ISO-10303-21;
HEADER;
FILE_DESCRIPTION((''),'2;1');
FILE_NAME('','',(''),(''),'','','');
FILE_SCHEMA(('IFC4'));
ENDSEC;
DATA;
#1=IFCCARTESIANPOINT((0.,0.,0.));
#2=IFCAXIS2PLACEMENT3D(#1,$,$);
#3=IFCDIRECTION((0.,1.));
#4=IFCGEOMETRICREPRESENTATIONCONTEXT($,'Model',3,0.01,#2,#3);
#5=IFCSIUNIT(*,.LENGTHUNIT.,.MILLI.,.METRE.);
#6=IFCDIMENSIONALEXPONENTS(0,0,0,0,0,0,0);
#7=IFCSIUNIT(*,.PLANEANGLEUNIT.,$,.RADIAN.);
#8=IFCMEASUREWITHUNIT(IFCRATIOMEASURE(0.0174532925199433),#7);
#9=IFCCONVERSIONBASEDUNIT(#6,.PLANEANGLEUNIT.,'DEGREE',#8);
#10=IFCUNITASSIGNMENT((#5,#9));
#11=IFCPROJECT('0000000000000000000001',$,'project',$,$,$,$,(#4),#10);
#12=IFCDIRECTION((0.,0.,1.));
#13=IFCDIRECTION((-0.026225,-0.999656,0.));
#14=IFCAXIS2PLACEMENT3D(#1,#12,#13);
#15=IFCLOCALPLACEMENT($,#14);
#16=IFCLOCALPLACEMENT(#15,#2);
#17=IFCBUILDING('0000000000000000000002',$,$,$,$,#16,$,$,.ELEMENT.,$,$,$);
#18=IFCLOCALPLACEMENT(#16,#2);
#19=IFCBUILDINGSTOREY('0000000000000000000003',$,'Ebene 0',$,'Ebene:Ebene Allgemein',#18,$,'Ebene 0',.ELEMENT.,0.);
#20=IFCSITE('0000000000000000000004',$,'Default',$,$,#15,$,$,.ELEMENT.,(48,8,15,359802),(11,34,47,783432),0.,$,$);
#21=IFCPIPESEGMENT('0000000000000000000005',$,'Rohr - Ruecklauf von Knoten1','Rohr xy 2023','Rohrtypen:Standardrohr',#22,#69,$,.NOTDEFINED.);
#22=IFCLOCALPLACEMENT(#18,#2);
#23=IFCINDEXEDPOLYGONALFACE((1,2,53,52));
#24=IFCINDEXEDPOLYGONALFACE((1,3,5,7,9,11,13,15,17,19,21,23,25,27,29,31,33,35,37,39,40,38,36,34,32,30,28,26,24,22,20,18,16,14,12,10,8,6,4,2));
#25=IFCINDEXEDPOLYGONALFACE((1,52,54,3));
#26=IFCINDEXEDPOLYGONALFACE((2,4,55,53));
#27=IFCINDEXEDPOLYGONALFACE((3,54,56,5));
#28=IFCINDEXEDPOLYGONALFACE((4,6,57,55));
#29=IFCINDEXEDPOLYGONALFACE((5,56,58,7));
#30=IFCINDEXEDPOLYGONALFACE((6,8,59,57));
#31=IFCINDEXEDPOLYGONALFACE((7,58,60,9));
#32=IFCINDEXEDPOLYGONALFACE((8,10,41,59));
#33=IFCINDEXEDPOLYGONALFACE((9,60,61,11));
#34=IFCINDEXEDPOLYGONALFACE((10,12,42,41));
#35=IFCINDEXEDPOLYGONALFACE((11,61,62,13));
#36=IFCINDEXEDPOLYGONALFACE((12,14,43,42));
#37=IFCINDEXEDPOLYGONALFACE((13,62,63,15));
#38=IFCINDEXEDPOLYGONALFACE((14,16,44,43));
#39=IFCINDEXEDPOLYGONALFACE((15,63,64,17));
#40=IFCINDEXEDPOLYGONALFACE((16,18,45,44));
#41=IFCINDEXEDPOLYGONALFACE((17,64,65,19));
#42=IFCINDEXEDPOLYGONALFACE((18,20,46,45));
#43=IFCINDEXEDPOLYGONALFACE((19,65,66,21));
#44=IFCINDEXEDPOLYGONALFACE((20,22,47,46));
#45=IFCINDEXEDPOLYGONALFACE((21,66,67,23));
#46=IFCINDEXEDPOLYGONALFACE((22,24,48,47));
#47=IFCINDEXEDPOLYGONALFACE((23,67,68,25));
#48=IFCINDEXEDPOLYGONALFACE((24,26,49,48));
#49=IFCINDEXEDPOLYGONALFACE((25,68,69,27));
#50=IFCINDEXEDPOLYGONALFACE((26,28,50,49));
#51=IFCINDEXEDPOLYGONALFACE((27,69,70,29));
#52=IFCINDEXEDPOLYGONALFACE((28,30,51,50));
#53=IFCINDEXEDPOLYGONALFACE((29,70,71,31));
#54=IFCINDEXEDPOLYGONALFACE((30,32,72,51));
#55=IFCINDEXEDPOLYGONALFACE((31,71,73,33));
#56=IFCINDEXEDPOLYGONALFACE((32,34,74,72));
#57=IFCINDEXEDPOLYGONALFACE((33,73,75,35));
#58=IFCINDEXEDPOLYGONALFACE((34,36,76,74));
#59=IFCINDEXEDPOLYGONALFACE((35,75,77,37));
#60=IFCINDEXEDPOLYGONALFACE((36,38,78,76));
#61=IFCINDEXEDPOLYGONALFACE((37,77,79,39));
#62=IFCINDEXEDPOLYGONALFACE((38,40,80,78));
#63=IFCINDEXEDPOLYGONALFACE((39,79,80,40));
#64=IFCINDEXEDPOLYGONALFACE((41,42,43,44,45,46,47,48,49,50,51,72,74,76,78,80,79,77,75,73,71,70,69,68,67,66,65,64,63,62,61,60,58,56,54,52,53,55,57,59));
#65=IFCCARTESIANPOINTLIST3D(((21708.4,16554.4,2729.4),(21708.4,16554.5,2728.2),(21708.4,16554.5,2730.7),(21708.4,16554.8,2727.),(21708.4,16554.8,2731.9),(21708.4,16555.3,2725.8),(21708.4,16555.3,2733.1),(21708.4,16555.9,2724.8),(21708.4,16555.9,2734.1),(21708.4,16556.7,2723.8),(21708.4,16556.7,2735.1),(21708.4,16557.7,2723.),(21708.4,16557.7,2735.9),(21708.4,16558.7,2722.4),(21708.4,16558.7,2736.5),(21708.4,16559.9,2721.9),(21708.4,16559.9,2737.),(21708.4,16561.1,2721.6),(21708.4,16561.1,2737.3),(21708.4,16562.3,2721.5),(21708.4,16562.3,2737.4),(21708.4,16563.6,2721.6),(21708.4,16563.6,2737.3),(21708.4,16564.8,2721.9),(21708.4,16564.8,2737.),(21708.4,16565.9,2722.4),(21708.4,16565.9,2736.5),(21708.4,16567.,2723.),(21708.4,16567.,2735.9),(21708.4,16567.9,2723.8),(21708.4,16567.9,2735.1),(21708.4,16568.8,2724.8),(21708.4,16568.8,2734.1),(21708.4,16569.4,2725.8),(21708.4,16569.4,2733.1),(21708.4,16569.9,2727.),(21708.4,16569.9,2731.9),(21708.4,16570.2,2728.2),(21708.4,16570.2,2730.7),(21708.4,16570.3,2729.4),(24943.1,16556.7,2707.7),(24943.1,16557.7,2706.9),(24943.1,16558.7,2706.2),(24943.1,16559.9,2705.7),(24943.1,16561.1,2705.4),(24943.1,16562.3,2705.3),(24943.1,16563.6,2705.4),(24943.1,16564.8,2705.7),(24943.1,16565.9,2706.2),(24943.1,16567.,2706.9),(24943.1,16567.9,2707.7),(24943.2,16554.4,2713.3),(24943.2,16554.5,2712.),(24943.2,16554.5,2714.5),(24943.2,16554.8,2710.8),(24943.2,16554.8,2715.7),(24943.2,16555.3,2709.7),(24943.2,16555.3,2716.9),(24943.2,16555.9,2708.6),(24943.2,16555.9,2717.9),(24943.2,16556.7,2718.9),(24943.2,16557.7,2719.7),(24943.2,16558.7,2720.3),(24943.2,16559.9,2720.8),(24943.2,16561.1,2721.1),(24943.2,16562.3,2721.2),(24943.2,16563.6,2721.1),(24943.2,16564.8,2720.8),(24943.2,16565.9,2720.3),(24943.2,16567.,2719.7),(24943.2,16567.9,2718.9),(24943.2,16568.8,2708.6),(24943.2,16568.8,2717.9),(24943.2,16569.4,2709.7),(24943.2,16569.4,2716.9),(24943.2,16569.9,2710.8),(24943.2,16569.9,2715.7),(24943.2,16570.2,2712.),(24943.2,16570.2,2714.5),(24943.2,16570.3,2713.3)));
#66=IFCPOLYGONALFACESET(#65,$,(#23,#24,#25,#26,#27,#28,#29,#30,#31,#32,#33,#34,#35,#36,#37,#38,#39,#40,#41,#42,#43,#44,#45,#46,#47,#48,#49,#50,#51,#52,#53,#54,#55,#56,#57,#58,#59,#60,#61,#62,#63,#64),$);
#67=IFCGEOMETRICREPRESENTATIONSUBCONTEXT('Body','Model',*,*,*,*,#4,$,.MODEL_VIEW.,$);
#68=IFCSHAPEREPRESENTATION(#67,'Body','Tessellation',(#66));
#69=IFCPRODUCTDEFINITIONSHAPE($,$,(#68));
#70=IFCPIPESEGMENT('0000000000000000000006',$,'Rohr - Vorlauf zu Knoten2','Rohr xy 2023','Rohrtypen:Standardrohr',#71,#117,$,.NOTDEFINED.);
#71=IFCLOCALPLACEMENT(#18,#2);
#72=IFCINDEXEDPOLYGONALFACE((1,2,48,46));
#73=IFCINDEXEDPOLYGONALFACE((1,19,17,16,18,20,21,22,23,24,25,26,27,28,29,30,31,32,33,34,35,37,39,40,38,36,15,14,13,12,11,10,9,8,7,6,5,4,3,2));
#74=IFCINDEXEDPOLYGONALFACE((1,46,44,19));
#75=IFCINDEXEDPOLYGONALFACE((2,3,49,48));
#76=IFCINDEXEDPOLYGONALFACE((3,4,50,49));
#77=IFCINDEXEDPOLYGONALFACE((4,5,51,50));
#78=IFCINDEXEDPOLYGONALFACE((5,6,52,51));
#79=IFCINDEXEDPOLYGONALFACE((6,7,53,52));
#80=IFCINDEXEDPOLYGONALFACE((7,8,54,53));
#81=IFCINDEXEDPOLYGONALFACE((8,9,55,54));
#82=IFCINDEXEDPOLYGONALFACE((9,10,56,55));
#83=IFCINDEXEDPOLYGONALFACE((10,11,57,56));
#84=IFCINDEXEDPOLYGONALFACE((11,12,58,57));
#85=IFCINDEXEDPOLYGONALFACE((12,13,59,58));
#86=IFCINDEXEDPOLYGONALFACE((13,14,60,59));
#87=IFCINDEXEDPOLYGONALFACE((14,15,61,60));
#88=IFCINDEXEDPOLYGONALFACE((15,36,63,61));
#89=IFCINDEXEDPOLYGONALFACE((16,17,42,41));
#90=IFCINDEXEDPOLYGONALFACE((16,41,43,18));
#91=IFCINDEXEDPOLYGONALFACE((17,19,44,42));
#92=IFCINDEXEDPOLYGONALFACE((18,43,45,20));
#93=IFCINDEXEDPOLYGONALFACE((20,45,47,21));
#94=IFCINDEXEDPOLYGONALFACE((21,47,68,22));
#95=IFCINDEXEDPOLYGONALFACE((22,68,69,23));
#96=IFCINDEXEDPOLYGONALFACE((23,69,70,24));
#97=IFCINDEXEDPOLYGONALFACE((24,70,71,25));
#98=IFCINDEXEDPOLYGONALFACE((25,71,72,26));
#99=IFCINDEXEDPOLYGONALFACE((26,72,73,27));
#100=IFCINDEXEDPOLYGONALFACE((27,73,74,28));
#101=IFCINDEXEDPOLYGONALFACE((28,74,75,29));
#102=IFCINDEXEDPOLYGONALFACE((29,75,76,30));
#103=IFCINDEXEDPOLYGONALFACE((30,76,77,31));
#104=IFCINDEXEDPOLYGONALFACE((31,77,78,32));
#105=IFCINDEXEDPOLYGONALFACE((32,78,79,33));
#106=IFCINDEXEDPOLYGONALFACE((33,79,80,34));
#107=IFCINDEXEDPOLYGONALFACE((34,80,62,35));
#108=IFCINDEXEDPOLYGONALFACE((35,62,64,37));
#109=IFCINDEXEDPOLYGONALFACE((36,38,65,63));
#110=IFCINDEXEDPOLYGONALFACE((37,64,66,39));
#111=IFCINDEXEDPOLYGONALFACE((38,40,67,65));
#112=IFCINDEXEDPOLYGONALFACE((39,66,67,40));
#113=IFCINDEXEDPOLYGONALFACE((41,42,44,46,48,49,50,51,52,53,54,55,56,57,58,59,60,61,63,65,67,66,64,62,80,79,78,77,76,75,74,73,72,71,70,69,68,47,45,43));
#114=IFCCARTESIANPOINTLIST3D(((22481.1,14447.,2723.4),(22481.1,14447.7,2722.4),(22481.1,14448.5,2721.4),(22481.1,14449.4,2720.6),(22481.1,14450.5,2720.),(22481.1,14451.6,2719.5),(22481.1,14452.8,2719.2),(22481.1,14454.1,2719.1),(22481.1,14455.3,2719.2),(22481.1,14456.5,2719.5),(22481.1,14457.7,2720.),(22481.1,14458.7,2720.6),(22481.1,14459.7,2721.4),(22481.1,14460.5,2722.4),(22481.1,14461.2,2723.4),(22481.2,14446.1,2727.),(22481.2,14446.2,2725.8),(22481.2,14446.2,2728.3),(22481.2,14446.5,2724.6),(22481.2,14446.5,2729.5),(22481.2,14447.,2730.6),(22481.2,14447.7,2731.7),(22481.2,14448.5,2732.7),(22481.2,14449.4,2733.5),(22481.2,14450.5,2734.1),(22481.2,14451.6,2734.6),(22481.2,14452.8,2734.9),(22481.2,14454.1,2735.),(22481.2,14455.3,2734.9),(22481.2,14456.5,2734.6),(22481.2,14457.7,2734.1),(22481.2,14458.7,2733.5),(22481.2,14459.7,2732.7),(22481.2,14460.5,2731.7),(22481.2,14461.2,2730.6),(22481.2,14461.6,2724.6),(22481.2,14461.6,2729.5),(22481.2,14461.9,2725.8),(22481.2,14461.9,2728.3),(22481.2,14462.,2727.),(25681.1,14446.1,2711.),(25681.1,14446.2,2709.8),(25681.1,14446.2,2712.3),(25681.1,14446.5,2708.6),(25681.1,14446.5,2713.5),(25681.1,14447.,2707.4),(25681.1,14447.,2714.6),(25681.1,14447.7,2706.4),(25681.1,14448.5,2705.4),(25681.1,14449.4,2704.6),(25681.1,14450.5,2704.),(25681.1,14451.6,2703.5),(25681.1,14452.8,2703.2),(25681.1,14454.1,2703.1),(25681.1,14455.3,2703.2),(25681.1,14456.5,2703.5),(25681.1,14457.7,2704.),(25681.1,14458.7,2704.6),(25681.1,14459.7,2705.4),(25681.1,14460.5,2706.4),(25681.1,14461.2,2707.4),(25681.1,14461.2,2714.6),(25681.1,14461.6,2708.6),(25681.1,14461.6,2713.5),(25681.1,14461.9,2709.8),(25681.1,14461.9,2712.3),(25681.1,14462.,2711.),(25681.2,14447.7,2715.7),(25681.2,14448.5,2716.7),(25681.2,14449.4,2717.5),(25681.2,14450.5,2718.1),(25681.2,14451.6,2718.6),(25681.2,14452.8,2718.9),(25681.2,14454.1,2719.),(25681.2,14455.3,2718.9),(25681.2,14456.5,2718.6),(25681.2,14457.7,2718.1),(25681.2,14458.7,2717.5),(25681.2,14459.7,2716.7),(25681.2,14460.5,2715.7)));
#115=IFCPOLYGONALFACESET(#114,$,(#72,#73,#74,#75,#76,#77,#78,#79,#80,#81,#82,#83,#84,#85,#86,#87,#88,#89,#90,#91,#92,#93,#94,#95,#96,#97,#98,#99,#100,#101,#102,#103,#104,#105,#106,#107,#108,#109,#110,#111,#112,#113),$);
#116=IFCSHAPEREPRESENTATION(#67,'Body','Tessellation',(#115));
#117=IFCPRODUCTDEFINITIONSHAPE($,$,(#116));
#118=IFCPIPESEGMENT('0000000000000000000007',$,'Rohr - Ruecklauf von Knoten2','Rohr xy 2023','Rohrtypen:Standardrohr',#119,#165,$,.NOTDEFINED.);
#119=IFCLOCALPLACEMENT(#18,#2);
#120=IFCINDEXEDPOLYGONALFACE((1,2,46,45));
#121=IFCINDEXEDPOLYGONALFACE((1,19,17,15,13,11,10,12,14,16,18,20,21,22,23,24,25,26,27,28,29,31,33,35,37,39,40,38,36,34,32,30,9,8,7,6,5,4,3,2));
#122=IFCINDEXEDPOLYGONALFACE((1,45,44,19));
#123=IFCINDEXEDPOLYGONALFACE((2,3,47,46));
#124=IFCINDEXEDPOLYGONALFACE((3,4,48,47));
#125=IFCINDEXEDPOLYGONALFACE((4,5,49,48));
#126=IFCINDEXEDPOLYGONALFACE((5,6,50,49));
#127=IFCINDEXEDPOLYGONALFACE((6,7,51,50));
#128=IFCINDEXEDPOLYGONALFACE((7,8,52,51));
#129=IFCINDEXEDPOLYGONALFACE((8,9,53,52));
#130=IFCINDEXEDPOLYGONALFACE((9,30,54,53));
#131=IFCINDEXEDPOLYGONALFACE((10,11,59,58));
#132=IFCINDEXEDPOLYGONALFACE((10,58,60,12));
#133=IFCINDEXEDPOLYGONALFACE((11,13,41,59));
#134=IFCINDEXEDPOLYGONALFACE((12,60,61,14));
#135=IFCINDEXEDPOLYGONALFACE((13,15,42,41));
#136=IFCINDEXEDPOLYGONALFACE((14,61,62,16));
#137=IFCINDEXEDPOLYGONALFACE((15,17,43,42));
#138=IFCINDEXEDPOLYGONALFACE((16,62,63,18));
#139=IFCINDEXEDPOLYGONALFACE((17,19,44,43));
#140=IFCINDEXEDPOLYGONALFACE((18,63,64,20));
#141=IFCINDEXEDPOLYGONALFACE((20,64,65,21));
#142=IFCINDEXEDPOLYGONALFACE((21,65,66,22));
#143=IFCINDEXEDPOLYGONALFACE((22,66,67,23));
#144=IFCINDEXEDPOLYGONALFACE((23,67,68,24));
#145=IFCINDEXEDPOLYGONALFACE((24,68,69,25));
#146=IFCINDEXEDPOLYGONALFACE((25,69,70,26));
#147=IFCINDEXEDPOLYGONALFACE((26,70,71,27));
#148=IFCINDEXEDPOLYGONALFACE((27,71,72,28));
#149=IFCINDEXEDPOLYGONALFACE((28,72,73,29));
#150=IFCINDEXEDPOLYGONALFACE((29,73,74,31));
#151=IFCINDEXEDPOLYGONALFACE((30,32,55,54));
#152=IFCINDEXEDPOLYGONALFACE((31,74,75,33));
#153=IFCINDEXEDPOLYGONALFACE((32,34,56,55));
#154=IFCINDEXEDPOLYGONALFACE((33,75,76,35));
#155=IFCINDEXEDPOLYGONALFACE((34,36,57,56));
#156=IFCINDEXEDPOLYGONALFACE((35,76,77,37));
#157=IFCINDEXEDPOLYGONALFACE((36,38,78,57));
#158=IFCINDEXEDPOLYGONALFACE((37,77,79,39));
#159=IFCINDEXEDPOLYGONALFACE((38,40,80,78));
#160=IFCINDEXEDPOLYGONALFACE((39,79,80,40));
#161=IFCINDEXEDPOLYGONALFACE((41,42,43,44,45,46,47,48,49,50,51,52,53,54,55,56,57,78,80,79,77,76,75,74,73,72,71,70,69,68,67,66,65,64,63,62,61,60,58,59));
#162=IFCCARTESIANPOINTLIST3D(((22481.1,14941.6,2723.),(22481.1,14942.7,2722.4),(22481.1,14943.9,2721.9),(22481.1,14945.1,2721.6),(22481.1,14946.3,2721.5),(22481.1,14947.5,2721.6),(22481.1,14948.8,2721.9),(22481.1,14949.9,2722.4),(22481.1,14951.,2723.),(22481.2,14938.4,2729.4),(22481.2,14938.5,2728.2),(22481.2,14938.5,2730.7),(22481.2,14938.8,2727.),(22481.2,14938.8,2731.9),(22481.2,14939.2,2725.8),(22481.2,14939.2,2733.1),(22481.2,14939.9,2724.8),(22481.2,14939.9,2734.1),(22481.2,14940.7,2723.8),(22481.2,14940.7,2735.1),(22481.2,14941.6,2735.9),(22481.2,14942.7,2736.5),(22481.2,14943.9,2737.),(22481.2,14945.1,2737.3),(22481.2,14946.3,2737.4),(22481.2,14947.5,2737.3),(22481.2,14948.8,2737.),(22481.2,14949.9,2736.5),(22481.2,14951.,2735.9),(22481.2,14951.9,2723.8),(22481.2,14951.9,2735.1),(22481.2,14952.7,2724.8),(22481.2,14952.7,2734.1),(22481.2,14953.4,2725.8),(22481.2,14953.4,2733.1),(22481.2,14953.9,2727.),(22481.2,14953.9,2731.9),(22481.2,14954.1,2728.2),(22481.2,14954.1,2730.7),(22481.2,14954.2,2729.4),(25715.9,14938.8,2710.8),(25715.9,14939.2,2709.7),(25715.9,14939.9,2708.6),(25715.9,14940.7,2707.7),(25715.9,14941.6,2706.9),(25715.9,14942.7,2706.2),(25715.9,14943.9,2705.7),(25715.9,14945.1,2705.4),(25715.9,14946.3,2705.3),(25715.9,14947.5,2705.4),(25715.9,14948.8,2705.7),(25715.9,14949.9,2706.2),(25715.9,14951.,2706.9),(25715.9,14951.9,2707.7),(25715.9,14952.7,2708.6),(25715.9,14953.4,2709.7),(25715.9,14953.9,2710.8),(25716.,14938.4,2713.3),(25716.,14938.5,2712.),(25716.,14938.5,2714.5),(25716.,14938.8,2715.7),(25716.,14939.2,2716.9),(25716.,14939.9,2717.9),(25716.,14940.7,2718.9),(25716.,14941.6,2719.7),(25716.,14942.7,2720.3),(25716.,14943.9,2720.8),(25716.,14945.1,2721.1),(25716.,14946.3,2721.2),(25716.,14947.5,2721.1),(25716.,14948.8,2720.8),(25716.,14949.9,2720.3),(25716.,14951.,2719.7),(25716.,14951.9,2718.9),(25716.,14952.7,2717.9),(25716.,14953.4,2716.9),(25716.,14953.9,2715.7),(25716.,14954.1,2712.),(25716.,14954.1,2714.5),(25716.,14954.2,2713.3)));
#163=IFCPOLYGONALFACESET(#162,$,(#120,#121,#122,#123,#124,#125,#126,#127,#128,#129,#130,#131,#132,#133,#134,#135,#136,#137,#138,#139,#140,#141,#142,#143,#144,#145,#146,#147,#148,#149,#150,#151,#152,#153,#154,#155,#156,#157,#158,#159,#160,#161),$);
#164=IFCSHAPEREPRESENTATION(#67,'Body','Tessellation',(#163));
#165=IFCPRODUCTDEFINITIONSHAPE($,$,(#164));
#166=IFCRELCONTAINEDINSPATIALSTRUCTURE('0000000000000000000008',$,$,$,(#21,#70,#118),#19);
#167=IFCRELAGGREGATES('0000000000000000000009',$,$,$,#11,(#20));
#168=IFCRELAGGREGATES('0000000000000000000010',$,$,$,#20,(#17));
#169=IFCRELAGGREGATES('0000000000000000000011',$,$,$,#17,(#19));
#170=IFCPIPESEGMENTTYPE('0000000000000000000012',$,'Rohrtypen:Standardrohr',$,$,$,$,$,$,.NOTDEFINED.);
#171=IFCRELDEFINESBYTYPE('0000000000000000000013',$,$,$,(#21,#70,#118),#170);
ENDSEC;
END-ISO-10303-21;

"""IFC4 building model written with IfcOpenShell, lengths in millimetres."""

from ifc_helpers import new_model, entity, si_unit, converted_unit, direction, frame, origin, place, context, subcontext, project, spatial, indexed_curve, outline, extrude, type_object, element, save


model = new_model("IFC4")

# Units and contexts
model_context = context("Model", 3, precision=0.01, world=origin(), true_north=direction((0.0, 1.0)))
body_context = subcontext(model_context, "Body", "Model", "MODEL_VIEW")
ifc_project = project(units=[si_unit("LENGTHUNIT", "METRE", prefix="MILLI"), converted_unit("PLANEANGLEUNIT", "DEGREE", entity("IfcRatioMeasure", 0.0174532925199433), si_unit("PLANEANGLEUNIT", "RADIAN"), dimensions=[0, 0, 0, 0, 0, 0, 0])], contexts=[model_context])

# Site, building, storey
site_placement = place(None, frame((0.0, 0.0, 0.0), z_axis=(0.0, 0.0, 1.0), x_axis=(-0.026225, -0.999656, 0.0)))
site = spatial("IfcSite", under=ifc_project, at=site_placement, Name="Default", CompositionType="ELEMENT", RefLatitude=(48, 8, 15, 359802), RefLongitude=(11, 34, 47, 783432), RefElevation=0.0)
building_placement = place(site_placement, origin())
building = spatial("IfcBuilding", under=site, at=building_placement, CompositionType="ELEMENT")
storey_placement = place(building_placement, origin())
storey = spatial("IfcBuildingStorey", under=building, at=storey_placement, Name="Ebene 0", ObjectType="Ebene:Ebene Allgemein", LongName="Ebene 0", CompositionType="ELEMENT", Elevation=0.0)

# Pipe segments
pipe_segment_type = type_object("IfcPipeSegmentType", Name="Rohrtypen:Standardrohr", PredefinedType="NOTDEFINED")
pipe_segment_1_placement = place(storey_placement, origin())
element("IfcPipeSegment", 1, at=pipe_segment_1_placement, inside=storey, type_object=pipe_segment_type, Name="Rohr - Ruecklauf von Knoten1", Description="Rohr xy 2023", ObjectType="Rohrtypen:Standardrohr", PredefinedType="NOTDEFINED", context=body_context, shape_type="SweptSolid", body=[
    extrude(outline(indexed_curve([(7.9, 0.0), (7.8, 1.2), (7.6, 2.5), (7.1, 3.6), (6.4, 4.7), (5.6, 5.6), (4.7, 6.4), (3.6, 7.1), (2.5, 7.6), (1.2, 7.8), (0.0, 7.9), (-1.2, 7.8), (-2.5, 7.6), (-3.6, 7.1), (-4.7, 6.4), (-5.6, 5.6), (-6.4, 4.7), (-7.1, 3.6), (-7.6, 2.5), (-7.8, 1.2), (-7.9, 0.0), (-7.8, -1.2), (-7.6, -2.5), (-7.1, -3.6), (-6.4, -4.7), (-5.6, -5.6), (-4.7, -6.4), (-3.6, -7.1), (-2.5, -7.6), (-1.2, -7.8), (0.0, -7.9), (1.2, -7.8), (2.5, -7.6), (3.6, -7.1), (4.7, -6.4), (5.6, -5.6), (6.4, -4.7), (7.1, -3.6), (7.6, -2.5), (7.8, -1.2), (7.9, 0.0)], self_intersect=False)), frame((24943.2, 16562.3, 2713.3), z_axis=(-0.999988, 0.0, 0.005), x_axis=(0.0, 1.0, 0.0)), (0.0, 0.0, 1.0), 3234.8),
])
pipe_segment_2_placement = place(storey_placement, origin())
element("IfcPipeSegment", 2, at=pipe_segment_2_placement, inside=storey, type_object=pipe_segment_type, Name="Rohr - Vorlauf zu Knoten2", Description="Rohr xy 2023", ObjectType="Rohrtypen:Standardrohr", PredefinedType="NOTDEFINED", context=body_context, shape_type="SweptSolid", body=[
    extrude(outline(indexed_curve([(7.9, 0.0), (7.8, 1.2), (7.6, 2.5), (7.1, 3.6), (6.4, 4.7), (5.6, 5.6), (4.7, 6.4), (3.6, 7.1), (2.5, 7.6), (1.2, 7.8), (0.0, 7.9), (-1.2, 7.8), (-2.5, 7.6), (-3.6, 7.1), (-4.7, 6.4), (-5.6, 5.6), (-6.4, 4.7), (-7.1, 3.6), (-7.6, 2.5), (-7.8, 1.2), (-7.9, 0.0), (-7.8, -1.2), (-7.6, -2.5), (-7.1, -3.6), (-6.4, -4.7), (-5.6, -5.6), (-4.7, -6.4), (-3.6, -7.1), (-2.5, -7.6), (-1.2, -7.8), (0.0, -7.9), (1.2, -7.8), (2.5, -7.6), (3.6, -7.1), (4.7, -6.4), (5.6, -5.6), (6.4, -4.7), (7.1, -3.6), (7.6, -2.5), (7.8, -1.2), (7.9, 0.0)], self_intersect=False)), frame((25681.1, 14454.1, 2711.0), z_axis=(-0.999988, 0.0, 0.005), x_axis=(0.0, 1.0, 0.0)), (0.0, 0.0, 1.0), 3200.0),
])
pipe_segment_3_placement = place(storey_placement, origin())
element("IfcPipeSegment", 3, at=pipe_segment_3_placement, inside=storey, type_object=pipe_segment_type, Name="Rohr - Ruecklauf von Knoten2", Description="Rohr xy 2023", ObjectType="Rohrtypen:Standardrohr", PredefinedType="NOTDEFINED", context=body_context, shape_type="SweptSolid", body=[
    extrude(outline(indexed_curve([(7.9, 0.0), (7.8, 1.2), (7.6, 2.5), (7.1, 3.6), (6.4, 4.7), (5.6, 5.6), (4.7, 6.4), (3.6, 7.1), (2.5, 7.6), (1.2, 7.8), (0.0, 7.9), (-1.2, 7.8), (-2.5, 7.6), (-3.6, 7.1), (-4.7, 6.4), (-5.6, 5.6), (-6.4, 4.7), (-7.1, 3.6), (-7.6, 2.5), (-7.8, 1.2), (-7.9, 0.0), (-7.8, -1.2), (-7.6, -2.5), (-7.1, -3.6), (-6.4, -4.7), (-5.6, -5.6), (-4.7, -6.4), (-3.6, -7.1), (-2.5, -7.6), (-1.2, -7.8), (0.0, -7.9), (1.2, -7.8), (2.5, -7.6), (3.6, -7.1), (4.7, -6.4), (5.6, -5.6), (6.4, -4.7), (7.1, -3.6), (7.6, -2.5), (7.8, -1.2), (7.9, 0.0)], self_intersect=False)), frame((25716.0, 14946.3, 2713.3), z_axis=(-0.999988, 0.0, 0.005), x_axis=(0.0, 1.0, 0.0)), (0.0, 0.0, 1.0), 3234.8),
])

save(model, "model.ifc")
